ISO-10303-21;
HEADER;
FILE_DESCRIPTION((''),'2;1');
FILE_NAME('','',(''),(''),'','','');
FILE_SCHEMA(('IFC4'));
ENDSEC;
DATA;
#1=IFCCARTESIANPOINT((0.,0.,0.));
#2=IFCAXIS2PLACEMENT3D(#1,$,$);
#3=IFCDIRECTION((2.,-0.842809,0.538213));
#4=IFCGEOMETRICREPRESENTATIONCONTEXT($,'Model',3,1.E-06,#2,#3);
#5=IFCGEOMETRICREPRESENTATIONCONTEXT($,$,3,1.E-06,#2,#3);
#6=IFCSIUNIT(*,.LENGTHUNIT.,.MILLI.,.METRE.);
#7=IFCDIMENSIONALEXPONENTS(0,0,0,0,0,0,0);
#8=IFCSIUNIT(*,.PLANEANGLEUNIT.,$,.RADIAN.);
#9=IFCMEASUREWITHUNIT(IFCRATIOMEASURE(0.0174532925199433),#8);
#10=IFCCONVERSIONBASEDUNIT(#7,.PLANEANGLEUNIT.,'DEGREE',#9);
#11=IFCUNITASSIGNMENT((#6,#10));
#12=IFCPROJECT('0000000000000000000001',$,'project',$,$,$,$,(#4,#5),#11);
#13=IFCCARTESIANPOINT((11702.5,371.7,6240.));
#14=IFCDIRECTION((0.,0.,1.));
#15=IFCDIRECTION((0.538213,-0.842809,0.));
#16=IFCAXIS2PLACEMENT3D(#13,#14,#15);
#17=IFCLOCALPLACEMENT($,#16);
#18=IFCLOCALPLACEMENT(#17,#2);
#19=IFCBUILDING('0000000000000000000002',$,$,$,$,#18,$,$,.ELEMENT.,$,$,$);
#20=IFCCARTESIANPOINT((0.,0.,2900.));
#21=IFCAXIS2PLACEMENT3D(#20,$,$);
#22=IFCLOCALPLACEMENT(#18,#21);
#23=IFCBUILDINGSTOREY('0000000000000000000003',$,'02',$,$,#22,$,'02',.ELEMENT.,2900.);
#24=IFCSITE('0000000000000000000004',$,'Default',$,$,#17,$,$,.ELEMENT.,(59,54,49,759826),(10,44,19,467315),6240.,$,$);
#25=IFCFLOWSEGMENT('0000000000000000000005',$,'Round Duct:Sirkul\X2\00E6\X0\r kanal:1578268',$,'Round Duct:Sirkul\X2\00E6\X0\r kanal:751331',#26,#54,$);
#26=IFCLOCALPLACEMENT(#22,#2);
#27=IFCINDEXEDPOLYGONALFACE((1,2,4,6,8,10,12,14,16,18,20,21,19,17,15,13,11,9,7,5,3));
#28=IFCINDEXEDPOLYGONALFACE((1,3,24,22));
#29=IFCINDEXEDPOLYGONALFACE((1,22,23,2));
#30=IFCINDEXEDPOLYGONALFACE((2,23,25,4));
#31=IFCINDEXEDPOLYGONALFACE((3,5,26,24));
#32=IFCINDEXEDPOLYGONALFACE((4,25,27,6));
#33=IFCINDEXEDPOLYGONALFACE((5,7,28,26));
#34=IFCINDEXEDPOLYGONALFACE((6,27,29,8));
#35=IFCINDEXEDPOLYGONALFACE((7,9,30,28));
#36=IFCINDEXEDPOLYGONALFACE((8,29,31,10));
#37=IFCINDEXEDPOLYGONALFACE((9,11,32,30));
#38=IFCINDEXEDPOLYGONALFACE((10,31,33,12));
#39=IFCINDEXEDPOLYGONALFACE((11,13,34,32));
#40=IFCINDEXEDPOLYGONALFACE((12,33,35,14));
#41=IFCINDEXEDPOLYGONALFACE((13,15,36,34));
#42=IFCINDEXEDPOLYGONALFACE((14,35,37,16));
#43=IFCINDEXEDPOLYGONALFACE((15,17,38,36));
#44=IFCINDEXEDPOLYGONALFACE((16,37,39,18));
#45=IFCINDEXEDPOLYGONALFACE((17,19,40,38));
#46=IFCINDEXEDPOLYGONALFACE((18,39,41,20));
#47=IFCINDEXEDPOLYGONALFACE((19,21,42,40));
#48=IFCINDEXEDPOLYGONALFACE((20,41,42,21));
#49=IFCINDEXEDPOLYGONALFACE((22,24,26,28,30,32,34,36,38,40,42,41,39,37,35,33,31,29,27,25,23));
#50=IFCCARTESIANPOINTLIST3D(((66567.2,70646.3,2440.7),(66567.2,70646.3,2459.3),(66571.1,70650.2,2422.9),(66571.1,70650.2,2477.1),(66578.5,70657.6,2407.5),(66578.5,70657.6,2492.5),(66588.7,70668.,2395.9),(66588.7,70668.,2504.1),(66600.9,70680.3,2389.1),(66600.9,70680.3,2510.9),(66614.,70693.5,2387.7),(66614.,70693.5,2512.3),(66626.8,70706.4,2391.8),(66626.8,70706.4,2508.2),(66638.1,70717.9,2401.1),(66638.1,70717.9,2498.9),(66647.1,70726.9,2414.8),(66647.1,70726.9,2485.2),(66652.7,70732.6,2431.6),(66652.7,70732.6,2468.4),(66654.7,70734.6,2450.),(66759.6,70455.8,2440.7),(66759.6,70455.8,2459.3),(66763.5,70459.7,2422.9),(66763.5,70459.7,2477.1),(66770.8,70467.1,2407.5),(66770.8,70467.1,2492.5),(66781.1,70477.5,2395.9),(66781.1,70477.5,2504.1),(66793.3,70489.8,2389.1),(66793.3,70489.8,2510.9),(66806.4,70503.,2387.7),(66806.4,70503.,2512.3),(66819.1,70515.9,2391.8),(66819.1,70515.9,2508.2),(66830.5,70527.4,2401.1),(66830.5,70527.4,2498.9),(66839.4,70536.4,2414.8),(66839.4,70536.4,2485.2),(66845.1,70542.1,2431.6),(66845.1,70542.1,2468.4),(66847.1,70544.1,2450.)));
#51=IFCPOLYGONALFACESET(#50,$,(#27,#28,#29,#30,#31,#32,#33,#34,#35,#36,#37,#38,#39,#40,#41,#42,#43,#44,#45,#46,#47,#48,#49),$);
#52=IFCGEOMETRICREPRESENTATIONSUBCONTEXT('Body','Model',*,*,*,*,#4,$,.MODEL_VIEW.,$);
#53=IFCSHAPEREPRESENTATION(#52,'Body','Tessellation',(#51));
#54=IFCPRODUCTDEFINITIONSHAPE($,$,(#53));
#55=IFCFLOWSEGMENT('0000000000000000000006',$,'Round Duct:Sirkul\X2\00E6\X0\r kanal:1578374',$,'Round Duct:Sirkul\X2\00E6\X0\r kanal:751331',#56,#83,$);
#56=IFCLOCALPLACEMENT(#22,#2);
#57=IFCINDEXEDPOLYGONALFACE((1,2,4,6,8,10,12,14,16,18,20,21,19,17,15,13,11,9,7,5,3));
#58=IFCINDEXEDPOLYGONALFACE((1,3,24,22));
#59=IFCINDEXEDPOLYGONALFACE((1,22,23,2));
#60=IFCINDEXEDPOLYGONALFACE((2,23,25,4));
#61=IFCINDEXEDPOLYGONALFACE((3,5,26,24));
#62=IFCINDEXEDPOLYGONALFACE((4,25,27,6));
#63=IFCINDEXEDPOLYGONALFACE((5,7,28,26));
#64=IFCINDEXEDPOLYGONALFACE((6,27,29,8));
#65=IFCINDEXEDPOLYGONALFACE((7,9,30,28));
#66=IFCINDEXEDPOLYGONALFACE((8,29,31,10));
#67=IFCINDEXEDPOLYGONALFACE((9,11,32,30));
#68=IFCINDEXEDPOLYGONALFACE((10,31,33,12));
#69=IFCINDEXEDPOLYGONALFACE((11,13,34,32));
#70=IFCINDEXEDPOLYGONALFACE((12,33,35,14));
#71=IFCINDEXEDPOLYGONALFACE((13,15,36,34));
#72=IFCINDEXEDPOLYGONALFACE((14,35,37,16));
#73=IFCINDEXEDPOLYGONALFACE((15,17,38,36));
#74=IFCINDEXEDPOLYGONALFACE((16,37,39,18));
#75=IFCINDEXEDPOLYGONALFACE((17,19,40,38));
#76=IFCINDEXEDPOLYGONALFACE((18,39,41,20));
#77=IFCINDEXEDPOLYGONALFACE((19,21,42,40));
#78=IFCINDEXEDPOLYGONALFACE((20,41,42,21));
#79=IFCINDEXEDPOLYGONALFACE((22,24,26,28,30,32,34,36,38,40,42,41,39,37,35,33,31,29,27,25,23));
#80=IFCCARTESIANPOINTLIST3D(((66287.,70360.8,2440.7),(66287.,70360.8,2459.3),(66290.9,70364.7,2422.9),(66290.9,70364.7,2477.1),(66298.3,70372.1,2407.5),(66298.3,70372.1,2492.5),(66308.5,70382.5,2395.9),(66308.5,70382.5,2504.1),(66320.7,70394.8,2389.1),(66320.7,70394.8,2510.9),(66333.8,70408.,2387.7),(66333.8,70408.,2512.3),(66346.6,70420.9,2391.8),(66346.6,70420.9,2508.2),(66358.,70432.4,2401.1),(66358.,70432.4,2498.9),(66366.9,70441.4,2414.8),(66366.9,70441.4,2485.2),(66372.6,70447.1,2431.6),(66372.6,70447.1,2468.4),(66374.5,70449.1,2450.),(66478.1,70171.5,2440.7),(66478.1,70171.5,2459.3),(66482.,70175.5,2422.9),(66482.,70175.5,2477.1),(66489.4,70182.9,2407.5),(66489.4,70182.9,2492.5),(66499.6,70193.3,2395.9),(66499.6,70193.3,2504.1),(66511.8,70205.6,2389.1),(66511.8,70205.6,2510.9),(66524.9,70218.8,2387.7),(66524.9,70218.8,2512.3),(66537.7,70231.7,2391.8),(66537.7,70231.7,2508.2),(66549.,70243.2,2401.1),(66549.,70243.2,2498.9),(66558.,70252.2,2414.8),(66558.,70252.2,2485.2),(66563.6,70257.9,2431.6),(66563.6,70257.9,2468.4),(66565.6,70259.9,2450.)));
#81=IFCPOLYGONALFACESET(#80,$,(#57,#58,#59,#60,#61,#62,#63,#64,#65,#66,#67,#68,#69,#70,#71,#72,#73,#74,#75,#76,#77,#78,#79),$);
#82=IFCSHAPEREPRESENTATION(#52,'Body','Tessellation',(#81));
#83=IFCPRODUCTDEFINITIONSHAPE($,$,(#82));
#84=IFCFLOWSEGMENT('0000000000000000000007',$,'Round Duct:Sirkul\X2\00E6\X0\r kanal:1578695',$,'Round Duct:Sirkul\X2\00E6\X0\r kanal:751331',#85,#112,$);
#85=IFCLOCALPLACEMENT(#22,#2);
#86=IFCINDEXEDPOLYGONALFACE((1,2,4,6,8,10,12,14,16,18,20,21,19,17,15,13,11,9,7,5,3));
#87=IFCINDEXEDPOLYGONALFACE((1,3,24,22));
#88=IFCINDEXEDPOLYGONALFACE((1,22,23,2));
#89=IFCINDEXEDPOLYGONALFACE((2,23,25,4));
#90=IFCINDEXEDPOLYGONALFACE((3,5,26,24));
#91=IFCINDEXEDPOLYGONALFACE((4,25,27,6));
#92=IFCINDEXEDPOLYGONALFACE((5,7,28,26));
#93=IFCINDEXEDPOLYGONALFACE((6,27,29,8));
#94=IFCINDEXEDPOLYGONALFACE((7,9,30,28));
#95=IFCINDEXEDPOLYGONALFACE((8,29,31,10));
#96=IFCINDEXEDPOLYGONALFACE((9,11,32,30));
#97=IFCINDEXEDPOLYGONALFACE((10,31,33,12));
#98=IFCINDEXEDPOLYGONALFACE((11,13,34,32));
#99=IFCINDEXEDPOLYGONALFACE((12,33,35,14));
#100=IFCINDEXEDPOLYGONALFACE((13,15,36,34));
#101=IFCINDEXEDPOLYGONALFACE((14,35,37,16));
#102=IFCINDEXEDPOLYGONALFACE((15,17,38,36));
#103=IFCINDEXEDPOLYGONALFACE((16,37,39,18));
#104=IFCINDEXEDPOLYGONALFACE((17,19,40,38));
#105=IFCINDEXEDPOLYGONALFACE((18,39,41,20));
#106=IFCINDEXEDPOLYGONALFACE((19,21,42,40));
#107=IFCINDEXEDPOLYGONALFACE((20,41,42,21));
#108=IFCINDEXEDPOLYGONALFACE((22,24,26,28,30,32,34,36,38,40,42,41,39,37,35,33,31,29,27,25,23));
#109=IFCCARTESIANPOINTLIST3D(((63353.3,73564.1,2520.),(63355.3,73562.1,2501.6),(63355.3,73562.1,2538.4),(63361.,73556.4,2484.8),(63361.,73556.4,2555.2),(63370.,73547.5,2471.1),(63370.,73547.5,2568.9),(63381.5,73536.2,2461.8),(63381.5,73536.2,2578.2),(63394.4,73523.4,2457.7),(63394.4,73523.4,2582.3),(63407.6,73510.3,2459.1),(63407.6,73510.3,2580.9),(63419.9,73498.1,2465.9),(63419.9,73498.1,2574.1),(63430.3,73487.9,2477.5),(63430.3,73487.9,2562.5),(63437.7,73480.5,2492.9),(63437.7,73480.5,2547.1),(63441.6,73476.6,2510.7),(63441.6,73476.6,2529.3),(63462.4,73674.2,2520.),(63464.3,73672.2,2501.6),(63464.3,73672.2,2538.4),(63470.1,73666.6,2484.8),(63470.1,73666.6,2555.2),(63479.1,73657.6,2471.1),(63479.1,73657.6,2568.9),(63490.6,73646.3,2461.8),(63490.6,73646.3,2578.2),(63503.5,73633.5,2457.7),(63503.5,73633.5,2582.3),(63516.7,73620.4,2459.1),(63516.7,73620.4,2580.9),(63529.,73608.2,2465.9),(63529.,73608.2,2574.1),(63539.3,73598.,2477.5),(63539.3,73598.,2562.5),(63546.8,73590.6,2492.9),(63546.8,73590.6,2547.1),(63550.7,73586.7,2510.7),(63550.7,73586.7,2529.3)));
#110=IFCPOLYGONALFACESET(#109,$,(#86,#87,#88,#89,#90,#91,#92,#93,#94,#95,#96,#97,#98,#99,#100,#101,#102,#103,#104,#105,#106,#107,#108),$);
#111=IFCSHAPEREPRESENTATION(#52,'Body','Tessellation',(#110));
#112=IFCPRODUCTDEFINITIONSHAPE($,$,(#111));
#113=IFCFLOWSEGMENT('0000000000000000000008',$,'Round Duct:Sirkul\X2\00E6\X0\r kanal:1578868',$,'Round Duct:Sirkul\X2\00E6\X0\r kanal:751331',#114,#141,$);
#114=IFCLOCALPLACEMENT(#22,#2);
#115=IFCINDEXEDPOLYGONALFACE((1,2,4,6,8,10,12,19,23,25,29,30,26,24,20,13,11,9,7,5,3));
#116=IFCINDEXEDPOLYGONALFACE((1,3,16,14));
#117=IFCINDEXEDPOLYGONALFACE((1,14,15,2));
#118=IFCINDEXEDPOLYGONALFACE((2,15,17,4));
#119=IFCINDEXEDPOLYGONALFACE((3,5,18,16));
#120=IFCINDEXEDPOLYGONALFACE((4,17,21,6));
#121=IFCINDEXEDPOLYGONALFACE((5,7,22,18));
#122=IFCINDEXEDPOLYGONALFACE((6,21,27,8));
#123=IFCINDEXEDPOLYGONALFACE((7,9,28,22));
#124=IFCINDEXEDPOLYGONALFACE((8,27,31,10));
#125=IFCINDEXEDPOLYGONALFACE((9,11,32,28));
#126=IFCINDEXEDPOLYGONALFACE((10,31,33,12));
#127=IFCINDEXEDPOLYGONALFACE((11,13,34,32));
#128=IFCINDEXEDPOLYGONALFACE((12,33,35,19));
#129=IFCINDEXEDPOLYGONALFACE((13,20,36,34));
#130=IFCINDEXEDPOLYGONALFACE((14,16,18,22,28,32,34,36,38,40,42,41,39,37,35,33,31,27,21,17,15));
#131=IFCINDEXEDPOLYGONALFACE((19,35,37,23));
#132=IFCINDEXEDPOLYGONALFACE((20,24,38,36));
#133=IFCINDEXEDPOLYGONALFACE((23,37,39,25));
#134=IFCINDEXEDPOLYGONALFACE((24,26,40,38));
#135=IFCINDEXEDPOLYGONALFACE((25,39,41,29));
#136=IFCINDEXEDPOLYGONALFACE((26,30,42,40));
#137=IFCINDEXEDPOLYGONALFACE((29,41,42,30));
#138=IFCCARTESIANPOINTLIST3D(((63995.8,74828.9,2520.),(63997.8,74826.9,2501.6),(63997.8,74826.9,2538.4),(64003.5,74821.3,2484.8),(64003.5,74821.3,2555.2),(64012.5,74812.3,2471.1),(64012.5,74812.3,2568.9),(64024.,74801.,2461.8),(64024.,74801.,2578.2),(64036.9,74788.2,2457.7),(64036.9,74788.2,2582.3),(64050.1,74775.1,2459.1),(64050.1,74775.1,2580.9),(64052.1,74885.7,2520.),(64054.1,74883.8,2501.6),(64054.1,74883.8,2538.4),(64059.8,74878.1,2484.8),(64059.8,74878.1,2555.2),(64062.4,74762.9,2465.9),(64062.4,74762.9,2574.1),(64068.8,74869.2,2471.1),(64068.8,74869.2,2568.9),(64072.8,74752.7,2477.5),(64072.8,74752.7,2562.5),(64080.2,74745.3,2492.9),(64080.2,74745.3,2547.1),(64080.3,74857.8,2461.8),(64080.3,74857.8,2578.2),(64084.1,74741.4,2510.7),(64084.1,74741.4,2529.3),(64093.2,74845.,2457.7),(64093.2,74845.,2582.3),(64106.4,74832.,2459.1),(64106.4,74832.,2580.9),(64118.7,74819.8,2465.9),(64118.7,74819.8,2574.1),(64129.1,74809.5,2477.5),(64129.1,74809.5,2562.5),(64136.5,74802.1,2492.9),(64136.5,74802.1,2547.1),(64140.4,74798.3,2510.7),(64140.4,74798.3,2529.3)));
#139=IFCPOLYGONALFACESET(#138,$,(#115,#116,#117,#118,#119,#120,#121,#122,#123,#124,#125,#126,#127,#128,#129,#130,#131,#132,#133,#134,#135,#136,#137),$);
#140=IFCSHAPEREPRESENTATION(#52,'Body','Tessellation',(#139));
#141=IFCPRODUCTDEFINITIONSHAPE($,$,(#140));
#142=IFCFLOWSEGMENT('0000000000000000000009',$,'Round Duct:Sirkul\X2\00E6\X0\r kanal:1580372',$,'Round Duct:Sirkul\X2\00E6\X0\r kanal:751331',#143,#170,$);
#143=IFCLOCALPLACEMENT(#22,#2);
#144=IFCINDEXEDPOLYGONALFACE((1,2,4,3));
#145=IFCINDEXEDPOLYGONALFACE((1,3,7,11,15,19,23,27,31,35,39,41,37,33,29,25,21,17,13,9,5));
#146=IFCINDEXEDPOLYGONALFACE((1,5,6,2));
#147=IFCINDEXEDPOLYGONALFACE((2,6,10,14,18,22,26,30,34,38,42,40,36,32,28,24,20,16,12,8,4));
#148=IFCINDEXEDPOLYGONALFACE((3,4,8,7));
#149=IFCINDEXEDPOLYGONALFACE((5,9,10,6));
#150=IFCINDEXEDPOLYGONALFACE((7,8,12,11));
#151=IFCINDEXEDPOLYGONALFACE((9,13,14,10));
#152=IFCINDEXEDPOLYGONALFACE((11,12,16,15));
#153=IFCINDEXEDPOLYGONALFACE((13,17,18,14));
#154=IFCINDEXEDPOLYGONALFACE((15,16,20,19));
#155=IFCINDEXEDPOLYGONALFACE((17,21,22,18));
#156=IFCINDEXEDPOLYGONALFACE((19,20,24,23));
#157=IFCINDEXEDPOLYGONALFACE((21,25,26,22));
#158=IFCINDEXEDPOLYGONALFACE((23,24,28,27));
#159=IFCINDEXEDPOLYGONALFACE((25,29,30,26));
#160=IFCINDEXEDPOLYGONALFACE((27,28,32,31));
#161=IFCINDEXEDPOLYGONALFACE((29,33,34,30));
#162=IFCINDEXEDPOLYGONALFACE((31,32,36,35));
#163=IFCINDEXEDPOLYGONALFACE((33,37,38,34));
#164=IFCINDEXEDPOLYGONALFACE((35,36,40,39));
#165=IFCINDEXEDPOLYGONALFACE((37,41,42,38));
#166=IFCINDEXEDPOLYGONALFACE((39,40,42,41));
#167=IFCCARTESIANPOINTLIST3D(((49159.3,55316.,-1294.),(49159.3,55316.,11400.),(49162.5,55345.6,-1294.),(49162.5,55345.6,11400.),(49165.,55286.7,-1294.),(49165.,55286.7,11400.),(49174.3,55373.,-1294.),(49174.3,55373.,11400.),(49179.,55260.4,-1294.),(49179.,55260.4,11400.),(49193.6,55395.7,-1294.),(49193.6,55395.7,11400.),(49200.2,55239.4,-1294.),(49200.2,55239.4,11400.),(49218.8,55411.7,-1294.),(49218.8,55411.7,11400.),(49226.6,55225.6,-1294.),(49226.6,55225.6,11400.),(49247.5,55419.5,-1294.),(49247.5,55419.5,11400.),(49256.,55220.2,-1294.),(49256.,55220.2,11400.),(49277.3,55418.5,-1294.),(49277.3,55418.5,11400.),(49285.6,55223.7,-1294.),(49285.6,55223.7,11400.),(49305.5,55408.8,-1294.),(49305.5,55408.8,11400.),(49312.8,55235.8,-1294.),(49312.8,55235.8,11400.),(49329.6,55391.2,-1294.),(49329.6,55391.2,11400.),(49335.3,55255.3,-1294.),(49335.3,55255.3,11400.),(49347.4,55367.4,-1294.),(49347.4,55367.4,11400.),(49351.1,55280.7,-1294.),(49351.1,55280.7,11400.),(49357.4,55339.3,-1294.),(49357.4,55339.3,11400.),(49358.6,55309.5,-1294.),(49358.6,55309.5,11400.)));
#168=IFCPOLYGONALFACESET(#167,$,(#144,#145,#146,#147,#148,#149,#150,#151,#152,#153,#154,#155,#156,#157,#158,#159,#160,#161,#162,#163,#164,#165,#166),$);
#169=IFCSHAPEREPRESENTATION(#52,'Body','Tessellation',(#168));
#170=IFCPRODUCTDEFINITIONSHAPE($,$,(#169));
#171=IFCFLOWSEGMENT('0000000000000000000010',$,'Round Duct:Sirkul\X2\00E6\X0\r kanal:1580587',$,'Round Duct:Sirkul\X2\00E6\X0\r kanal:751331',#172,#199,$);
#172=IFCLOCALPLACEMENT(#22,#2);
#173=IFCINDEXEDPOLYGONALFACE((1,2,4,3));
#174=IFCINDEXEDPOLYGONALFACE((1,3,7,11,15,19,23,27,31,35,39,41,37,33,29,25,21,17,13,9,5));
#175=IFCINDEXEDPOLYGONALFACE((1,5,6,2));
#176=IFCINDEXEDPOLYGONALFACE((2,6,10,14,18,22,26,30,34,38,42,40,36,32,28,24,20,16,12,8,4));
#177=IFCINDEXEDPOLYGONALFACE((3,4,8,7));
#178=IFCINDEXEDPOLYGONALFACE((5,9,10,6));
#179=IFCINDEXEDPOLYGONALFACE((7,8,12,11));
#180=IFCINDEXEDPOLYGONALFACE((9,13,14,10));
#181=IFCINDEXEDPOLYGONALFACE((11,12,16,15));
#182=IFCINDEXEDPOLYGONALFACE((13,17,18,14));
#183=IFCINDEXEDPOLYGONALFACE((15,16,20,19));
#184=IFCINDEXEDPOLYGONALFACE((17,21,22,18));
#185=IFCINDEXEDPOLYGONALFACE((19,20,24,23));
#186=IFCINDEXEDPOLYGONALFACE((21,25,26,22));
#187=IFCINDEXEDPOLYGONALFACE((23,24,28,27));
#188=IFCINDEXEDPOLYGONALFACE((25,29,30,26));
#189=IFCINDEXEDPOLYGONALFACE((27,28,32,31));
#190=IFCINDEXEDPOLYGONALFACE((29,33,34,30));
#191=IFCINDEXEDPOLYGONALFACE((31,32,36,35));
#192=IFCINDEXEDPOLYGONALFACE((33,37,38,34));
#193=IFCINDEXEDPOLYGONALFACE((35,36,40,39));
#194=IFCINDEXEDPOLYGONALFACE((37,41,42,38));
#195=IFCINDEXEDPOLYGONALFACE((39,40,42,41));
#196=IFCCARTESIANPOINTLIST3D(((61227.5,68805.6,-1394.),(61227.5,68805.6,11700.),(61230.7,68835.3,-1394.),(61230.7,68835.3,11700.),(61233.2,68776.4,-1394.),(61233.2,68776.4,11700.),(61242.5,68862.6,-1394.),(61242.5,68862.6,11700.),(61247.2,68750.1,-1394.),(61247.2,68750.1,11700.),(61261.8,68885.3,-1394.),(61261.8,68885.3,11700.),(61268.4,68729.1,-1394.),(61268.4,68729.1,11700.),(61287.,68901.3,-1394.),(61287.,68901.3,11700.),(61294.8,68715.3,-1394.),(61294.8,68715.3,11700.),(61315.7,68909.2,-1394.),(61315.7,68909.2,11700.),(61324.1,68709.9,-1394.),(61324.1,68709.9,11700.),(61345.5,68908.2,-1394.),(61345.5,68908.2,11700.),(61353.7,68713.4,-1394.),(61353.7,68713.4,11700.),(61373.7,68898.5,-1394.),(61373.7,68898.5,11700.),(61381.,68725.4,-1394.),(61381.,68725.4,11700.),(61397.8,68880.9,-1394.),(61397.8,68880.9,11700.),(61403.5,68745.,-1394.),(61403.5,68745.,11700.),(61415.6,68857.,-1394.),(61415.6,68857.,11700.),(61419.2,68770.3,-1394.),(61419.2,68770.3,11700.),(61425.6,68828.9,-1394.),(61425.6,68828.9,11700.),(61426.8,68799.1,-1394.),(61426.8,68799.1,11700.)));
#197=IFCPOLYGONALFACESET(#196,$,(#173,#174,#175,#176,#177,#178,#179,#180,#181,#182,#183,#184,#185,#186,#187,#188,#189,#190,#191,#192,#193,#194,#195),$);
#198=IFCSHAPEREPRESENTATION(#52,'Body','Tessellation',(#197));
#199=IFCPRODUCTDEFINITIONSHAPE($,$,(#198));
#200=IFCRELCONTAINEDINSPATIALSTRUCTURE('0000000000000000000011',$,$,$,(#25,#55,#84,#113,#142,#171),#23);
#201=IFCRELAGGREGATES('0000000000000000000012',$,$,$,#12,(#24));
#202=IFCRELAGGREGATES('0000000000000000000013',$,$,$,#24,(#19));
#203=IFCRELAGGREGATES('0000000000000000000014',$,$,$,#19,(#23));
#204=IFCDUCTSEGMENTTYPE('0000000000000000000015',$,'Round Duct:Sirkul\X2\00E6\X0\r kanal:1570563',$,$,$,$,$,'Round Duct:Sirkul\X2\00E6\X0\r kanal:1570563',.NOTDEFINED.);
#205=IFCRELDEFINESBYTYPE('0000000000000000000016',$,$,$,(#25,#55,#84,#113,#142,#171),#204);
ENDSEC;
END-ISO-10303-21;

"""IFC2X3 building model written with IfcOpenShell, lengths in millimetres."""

from ifc_helpers import new_model, entity, si_unit, converted_unit, direction, frame, frame_2d, origin, origin_2d_with_axis, place, context, subcontext, project, spatial, circle, extrude, type_object, element, save


model = new_model("IFC2X3")

# Units and contexts
model_context = context("Model", 3, precision=1e-06, world=origin(), true_north=direction((2.0, -0.842809, 0.538213)))
context_of_model = context(None, 3, precision=1e-06, world=origin(), true_north=direction((2.0, -0.842809, 0.538213)))
body_context = subcontext(model_context, "Body", "Model", "MODEL_VIEW")
ifc_project = project(units=[si_unit("LENGTHUNIT", "METRE", prefix="MILLI"), converted_unit("PLANEANGLEUNIT", "DEGREE", entity("IfcRatioMeasure", 0.0174532925199433), si_unit("PLANEANGLEUNIT", "RADIAN"), dimensions=[0, 0, 0, 0, 0, 0, 0])], contexts=[model_context, context_of_model])

# Site, building, storey
site_placement = place(None, frame((11702.5, 371.7, 6240.0), z_axis=(0.0, 0.0, 1.0), x_axis=(0.538213, -0.842809, 0.0)))
site = spatial("IfcSite", under=ifc_project, at=site_placement, Name="Default", CompositionType="ELEMENT", RefLatitude=(59, 54, 49, 759826), RefLongitude=(10, 44, 19, 467315), RefElevation=6240.0)
building_placement = place(site_placement, origin())
building = spatial("IfcBuilding", under=site, at=building_placement, CompositionType="ELEMENT")
storey_placement = place(building_placement, frame((0.0, 0.0, 2900.0)))
storey = spatial("IfcBuildingStorey", under=building, at=storey_placement, Name="02", LongName="02", CompositionType="ELEMENT", Elevation=2900.0)

# Flow segments
duct_segment_type = type_object("IfcDuctSegmentType", Name="Round Duct:Sirkulær kanal:1570563", ElementType="Round Duct:Sirkulær kanal:1570563", PredefinedType="NOTDEFINED")
flow_segment_1_placement = place(storey_placement, origin())
element("IfcFlowSegment", 1, at=flow_segment_1_placement, inside=storey, type_object=duct_segment_type, Name="Round Duct:Sirkulær kanal:1578268", ObjectType="Round Duct:Sirkulær kanal:751331", context=body_context, shape_type="SweptSolid", body=[
    extrude(circle(Radius=62.5, at=origin_2d_with_axis()), frame((66610.7, 70690.2, 2450.0), z_axis=(0.710554, -0.703643, 0.0), x_axis=(0.703643, 0.710554, 0.0)), (0.0, 0.0, 1.0), 270.7),
])
flow_segment_2_placement = place(storey_placement, origin())
element("IfcFlowSegment", 2, at=flow_segment_2_placement, inside=storey, type_object=duct_segment_type, Name="Round Duct:Sirkulær kanal:1578374", ObjectType="Round Duct:Sirkulær kanal:751331", context=body_context, shape_type="SweptSolid", body=[
    extrude(circle(Radius=62.5, at=origin_2d_with_axis()), frame((66521.6, 70215.5, 2450.0), z_axis=(-0.710554, 0.703643, 0.0), x_axis=(0.703643, 0.710554, 0.0)), (0.0, 0.0, 1.0), 268.9),
])
flow_segment_3_placement = place(storey_placement, origin())
element("IfcFlowSegment", 3, at=flow_segment_3_placement, inside=storey, type_object=duct_segment_type, Name="Round Duct:Sirkulær kanal:1578695", ObjectType="Round Duct:Sirkulær kanal:751331", context=body_context, shape_type="SweptSolid", body=[
    extrude(circle(Radius=62.5, at=frame_2d((0.0, 0.0), x_axis=(1.0, 0.0))), frame((63397.7, 73520.1, 2520.0), z_axis=(0.703643, 0.710554, 0.0), x_axis=(-0.710554, 0.703643, 0.0)), (0.0, 0.0, 1.0), 155.0),
])
flow_segment_4_placement = place(storey_placement, origin())
element("IfcFlowSegment", 4, at=flow_segment_4_placement, inside=storey, type_object=duct_segment_type, Name="Round Duct:Sirkulær kanal:1578868", ObjectType="Round Duct:Sirkulær kanal:751331", context=body_context, shape_type="SweptSolid", body=[
    extrude(circle(Radius=62.5, at=origin_2d_with_axis()), frame((64040.2, 74784.9, 2520.0), z_axis=(0.703643, 0.710554, 0.0), x_axis=(-0.710554, 0.703643, 0.0)), (0.0, 0.0, 1.0), 80.0),
])
flow_segment_5_placement = place(storey_placement, origin())
element("IfcFlowSegment", 5, at=flow_segment_5_placement, inside=storey, type_object=duct_segment_type, Name="Round Duct:Sirkulær kanal:1580372", ObjectType="Round Duct:Sirkulær kanal:751331", context=body_context, shape_type="SweptSolid", body=[
    extrude(circle(Radius=100.0, at=origin_2d_with_axis()), frame((49259.2, 55320.2, -1294.0), z_axis=(0.0, 0.0, 1.0), x_axis=(0.703643, 0.710554, 0.0)), (0.0, 0.0, 1.0), 12694.0),
])
flow_segment_6_placement = place(storey_placement, origin())
element("IfcFlowSegment", 6, at=flow_segment_6_placement, inside=storey, type_object=duct_segment_type, Name="Round Duct:Sirkulær kanal:1580587", ObjectType="Round Duct:Sirkulær kanal:751331", context=body_context, shape_type="SweptSolid", body=[
    extrude(circle(Radius=100.0, at=origin_2d_with_axis()), frame((61327.4, 68809.9, -1394.0), z_axis=(0.0, 0.0, 1.0), x_axis=(0.703643, 0.710554, 0.0)), (0.0, 0.0, 1.0), 13094.0),
])

save(model, "model.ifc")
